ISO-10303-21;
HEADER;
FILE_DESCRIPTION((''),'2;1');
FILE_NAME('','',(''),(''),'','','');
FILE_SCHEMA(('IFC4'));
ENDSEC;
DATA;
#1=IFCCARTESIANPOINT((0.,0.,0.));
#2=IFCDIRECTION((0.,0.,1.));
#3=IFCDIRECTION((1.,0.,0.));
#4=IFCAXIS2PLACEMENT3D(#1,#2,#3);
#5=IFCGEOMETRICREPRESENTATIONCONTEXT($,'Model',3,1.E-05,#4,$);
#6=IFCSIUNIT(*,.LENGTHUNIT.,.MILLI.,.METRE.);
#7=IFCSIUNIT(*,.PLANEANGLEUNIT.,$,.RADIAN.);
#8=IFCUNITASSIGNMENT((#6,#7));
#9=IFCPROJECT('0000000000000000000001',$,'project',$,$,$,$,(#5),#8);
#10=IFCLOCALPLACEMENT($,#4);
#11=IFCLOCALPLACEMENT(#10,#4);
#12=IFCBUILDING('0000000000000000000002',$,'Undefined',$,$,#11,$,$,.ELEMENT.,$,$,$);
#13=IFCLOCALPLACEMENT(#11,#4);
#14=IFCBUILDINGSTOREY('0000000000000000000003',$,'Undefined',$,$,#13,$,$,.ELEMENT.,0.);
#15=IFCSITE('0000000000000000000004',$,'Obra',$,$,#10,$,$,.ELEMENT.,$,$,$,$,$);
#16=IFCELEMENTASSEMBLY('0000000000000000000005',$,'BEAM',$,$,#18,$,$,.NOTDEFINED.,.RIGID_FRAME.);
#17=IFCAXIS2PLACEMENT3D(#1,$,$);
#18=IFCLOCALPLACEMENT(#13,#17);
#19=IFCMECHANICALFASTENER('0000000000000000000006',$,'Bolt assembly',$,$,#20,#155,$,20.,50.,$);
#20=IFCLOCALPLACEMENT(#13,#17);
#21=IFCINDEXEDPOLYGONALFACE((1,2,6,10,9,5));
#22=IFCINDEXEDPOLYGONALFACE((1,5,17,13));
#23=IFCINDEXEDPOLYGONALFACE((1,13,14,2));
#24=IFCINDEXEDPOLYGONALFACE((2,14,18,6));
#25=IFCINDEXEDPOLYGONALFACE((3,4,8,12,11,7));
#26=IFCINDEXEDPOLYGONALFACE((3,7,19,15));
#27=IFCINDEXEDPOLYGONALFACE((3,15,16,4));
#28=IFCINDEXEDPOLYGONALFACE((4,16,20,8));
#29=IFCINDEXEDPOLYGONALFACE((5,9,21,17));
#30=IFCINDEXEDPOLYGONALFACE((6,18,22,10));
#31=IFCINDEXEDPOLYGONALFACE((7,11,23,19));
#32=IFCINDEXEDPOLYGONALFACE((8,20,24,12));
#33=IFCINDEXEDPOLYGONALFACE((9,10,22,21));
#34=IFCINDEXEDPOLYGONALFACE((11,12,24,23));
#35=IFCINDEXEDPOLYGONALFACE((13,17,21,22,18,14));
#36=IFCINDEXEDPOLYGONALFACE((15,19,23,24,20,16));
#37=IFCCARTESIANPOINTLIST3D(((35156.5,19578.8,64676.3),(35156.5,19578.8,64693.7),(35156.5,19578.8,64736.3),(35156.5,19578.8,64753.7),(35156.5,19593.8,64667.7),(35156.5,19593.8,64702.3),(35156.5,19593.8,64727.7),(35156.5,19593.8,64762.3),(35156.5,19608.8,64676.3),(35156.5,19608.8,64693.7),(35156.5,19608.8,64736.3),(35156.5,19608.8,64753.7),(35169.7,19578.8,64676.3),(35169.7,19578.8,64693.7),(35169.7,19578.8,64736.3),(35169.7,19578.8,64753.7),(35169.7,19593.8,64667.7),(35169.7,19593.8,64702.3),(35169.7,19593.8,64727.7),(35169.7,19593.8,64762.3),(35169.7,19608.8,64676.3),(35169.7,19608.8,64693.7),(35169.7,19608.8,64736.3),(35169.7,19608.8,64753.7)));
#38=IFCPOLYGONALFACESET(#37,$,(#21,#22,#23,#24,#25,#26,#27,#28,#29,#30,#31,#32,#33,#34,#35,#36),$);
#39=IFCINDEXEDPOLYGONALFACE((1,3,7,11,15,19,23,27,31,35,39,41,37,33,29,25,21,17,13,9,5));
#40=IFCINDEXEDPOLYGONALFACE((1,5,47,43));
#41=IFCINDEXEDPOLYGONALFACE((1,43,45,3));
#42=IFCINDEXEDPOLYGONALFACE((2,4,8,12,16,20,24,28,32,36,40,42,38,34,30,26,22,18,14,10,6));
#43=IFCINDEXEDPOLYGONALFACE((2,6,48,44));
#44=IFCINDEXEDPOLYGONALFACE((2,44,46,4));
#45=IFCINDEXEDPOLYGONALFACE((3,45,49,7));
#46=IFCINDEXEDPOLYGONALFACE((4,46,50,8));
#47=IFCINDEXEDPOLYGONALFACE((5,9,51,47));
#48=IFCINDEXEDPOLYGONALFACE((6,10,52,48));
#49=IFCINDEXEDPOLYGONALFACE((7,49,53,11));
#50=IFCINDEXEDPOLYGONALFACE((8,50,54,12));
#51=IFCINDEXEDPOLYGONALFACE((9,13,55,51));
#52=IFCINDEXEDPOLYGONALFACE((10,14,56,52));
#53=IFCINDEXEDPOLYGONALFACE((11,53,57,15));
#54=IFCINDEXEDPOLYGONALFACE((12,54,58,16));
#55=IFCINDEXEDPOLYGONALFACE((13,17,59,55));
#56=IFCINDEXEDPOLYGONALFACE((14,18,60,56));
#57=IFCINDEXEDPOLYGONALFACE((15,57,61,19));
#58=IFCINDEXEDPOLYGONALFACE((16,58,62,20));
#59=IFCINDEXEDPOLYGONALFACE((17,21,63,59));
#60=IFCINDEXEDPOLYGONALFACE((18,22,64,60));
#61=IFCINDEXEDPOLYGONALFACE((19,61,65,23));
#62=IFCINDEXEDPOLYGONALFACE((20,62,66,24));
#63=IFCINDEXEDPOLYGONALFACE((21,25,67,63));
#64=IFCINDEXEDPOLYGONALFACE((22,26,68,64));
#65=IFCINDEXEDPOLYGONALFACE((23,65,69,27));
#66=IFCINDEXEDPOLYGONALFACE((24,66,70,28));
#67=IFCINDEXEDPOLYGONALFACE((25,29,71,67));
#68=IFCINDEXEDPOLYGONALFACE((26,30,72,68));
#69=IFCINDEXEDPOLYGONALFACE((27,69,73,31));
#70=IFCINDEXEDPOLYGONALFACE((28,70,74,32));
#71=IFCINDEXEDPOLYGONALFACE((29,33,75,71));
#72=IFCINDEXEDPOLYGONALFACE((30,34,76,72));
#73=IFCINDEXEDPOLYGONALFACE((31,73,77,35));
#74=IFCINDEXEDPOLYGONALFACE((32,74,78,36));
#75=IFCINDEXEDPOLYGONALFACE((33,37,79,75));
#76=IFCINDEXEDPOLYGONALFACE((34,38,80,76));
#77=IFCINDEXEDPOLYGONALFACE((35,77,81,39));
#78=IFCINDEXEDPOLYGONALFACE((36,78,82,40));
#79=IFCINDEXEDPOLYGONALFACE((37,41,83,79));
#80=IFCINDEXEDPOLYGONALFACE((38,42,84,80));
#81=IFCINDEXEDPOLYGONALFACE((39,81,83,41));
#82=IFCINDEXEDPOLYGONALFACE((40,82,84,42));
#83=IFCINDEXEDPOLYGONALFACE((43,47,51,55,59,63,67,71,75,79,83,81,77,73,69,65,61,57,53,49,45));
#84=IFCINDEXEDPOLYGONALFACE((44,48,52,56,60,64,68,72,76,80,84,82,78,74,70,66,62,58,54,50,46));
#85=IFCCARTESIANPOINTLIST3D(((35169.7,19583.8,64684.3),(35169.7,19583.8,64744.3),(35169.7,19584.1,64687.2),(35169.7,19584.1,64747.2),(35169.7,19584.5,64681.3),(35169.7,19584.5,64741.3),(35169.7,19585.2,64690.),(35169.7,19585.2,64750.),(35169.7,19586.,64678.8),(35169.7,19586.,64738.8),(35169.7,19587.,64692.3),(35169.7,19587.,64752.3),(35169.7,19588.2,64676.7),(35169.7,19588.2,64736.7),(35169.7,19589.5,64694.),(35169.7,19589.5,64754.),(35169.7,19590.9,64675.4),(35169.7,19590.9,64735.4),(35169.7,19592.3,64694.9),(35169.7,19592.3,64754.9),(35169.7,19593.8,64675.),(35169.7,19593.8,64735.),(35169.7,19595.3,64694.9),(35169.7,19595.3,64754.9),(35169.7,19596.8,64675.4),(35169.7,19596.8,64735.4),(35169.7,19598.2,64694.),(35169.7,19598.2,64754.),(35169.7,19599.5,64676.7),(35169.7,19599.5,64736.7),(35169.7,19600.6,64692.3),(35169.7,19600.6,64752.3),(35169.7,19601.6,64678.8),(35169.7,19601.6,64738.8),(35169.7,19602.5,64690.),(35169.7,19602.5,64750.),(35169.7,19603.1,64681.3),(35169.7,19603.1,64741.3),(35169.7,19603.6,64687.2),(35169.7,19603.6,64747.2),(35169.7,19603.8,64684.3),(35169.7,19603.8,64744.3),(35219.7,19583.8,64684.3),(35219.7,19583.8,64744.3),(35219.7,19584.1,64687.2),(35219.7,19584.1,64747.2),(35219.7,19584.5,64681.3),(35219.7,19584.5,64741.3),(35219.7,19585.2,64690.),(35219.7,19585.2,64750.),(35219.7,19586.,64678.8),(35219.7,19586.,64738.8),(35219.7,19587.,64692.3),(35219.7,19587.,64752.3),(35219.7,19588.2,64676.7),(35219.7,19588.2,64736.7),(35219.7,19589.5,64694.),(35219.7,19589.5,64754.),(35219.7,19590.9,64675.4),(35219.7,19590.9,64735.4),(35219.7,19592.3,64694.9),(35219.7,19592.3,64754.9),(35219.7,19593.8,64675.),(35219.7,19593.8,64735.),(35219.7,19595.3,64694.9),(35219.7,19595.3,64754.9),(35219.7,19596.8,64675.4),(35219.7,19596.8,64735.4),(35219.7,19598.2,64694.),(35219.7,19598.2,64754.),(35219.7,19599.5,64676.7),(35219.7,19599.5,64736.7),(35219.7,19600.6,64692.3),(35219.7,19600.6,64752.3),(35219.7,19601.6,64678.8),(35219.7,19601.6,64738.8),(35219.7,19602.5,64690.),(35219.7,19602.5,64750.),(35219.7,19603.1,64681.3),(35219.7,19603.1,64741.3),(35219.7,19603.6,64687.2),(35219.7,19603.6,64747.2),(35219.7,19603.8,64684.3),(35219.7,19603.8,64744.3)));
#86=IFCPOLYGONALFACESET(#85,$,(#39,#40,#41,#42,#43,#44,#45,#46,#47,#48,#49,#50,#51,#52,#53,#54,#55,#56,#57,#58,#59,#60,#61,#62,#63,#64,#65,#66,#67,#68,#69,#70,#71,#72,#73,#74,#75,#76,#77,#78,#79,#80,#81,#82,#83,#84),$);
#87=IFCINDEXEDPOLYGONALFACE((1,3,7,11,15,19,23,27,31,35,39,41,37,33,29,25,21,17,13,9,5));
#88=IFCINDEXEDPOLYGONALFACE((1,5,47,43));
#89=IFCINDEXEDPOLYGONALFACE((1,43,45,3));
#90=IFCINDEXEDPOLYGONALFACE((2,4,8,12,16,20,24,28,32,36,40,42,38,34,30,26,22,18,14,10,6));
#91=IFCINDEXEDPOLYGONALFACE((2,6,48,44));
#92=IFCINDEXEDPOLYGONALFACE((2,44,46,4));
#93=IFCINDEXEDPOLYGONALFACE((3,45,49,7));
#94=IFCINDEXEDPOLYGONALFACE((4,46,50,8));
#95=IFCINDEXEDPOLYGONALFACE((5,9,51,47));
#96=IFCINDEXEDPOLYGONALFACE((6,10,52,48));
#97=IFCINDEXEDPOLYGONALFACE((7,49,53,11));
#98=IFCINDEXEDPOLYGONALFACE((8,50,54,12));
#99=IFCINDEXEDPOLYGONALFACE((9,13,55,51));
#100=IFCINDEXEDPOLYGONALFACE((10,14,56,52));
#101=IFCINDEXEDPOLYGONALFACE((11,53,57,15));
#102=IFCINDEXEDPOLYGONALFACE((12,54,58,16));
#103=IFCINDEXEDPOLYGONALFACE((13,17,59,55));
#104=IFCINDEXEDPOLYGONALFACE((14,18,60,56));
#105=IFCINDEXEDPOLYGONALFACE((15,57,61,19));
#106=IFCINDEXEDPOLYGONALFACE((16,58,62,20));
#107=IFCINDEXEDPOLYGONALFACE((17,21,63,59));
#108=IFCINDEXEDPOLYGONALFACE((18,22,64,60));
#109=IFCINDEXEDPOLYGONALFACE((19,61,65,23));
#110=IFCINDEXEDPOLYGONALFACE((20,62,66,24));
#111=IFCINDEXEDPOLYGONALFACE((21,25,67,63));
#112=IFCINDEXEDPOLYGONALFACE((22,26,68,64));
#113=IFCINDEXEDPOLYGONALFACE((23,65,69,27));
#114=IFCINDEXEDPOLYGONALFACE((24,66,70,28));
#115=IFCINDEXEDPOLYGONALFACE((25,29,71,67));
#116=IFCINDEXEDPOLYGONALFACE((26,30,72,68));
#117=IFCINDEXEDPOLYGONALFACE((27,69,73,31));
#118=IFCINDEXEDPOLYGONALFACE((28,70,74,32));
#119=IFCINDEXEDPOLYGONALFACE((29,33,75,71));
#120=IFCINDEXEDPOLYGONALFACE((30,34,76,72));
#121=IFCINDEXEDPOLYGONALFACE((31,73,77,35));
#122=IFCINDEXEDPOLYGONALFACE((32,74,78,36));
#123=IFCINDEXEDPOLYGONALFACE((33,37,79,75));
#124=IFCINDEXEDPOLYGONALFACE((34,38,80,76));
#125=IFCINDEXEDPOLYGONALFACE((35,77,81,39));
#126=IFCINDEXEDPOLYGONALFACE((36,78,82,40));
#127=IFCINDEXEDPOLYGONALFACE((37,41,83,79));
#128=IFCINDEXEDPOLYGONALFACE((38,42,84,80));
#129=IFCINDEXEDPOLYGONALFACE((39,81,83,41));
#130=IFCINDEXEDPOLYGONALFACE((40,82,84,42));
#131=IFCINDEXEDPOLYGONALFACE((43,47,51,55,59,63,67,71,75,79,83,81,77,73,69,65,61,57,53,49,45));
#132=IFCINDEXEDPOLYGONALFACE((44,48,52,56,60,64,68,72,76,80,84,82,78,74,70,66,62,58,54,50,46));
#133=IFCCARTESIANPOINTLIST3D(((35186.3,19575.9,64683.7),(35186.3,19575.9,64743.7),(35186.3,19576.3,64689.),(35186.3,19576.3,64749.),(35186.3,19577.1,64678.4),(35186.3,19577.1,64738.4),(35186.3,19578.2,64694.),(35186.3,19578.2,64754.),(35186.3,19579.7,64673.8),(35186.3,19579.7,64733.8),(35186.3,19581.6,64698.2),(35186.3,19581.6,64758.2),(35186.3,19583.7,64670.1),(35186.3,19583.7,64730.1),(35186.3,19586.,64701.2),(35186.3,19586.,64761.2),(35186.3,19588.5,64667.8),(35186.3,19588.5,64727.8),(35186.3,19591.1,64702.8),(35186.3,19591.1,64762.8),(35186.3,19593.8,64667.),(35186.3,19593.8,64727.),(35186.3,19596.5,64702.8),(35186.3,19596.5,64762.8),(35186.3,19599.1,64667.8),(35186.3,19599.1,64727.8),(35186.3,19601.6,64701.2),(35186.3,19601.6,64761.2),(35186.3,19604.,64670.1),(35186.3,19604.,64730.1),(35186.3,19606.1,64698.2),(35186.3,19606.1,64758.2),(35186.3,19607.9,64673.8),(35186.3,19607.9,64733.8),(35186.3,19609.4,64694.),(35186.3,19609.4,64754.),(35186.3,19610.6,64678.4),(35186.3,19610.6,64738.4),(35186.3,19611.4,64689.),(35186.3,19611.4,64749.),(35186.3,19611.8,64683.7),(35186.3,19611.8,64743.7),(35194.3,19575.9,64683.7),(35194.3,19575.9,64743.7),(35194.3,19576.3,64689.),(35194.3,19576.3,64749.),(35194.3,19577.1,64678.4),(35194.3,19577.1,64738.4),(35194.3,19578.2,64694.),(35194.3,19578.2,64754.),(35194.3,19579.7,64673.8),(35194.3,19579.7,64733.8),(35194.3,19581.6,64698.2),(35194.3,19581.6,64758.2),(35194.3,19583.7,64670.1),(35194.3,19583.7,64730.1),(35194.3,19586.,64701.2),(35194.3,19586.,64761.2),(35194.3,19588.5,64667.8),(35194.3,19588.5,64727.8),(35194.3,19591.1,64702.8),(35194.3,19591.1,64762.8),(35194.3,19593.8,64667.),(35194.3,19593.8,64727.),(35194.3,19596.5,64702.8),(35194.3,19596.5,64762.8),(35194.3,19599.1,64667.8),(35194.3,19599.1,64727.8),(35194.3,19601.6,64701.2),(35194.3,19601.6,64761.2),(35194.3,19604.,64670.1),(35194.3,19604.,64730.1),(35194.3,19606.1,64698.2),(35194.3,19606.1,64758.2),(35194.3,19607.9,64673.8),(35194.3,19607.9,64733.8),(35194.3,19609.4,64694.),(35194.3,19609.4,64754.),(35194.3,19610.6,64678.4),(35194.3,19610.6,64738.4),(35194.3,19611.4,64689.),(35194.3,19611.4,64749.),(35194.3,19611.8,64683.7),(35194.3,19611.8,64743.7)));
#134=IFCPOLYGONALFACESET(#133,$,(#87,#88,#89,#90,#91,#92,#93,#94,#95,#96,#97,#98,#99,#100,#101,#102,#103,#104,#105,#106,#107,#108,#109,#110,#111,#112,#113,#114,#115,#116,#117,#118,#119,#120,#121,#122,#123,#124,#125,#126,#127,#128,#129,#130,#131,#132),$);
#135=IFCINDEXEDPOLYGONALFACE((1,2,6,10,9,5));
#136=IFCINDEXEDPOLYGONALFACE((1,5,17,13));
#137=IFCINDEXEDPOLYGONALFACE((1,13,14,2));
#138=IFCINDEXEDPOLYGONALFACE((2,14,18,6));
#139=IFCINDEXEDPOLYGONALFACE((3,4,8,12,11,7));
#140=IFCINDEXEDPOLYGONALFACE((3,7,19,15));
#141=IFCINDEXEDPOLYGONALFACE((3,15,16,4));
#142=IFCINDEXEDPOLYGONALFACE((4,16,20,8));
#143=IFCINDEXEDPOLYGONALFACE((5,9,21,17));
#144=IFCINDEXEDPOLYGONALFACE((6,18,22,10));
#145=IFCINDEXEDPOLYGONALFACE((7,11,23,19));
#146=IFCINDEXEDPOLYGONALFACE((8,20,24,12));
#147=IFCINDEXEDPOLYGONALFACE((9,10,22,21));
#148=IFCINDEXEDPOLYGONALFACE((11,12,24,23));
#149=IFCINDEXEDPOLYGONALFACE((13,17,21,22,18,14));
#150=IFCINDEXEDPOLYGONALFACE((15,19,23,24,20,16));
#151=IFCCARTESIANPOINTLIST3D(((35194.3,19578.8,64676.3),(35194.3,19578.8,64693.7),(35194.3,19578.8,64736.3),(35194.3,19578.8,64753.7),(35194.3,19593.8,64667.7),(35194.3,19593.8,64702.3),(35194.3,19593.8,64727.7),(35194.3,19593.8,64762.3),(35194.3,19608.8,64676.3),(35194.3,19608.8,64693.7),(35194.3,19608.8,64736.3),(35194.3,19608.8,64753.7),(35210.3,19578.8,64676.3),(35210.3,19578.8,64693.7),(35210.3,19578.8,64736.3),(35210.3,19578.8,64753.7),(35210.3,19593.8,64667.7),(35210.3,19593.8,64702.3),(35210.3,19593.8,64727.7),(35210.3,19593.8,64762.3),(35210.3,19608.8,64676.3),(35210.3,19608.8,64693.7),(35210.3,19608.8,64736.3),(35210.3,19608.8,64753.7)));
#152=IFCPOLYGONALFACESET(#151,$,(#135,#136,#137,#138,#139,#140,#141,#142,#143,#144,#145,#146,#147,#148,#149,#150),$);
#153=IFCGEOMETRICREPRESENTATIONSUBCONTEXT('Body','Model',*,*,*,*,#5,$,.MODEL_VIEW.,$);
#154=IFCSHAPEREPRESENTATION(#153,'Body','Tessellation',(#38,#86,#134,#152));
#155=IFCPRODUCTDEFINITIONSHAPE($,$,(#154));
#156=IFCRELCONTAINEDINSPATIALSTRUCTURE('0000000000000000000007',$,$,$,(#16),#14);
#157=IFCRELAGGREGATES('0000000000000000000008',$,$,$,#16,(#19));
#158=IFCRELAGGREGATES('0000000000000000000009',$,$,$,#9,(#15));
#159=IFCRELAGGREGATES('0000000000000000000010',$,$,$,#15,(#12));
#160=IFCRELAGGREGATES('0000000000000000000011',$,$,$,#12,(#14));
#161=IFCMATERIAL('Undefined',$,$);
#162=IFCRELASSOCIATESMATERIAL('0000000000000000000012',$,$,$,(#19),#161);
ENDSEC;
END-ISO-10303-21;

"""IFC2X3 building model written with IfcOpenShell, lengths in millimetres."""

from ifc_helpers import new_model, si_unit, frame, origin_with_axes, origin_2d_with_axis, place, context, subcontext, project, spatial, polyline, circle, outline, extrude, source, transform, mapped, material, element, aggregate, save


model = new_model("IFC2X3")

# Units and contexts
model_context = context("Model", 3, precision=1e-05, world=origin_with_axes())
body_context = subcontext(model_context, "Body", "Model", "MODEL_VIEW")
ifc_project = project(units=[si_unit("LENGTHUNIT", "METRE", prefix="MILLI"), si_unit("PLANEANGLEUNIT", "RADIAN")], contexts=[model_context])

# Site, building, storey
site_placement = place(None, origin_with_axes())
site = spatial("IfcSite", under=ifc_project, at=site_placement, Name="Obra", CompositionType="ELEMENT")
building_placement = place(site_placement, origin_with_axes())
building = spatial("IfcBuilding", under=site, at=building_placement, Name="Undefined", CompositionType="ELEMENT")
storey_placement = place(building_placement, origin_with_axes())
storey = spatial("IfcBuildingStorey", under=building, at=storey_placement, Name="Undefined", CompositionType="ELEMENT", Elevation=0.0)

# Element assembly, mechanical fastener
ifc_material = material(Name="Undefined")
shared_shape_1 = source(origin_with_axes(), body_context, "Body", "SweptSolid", [
    extrude(outline(polyline([(17.3, 0.0), (8.7, 15.0), (-8.7, 15.0), (-17.3, 0.0), (-8.7, -15.0), (8.7, -15.0), (17.3, 0.0)])), frame((0.0, -26.5, 0.0), z_axis=(0.0, 1.0, 0.0), x_axis=(1.0, 0.0, 0.0)), (0.0, 0.0, 1.0), 13.2),
    extrude(circle(Radius=10.0, at=origin_2d_with_axis()), frame((0.0, -13.3, 0.0), z_axis=(0.0, 1.0, 0.0), x_axis=(1.0, 0.0, 0.0)), (0.0, 0.0, 1.0), 50.0),
    extrude(circle(Radius=18.0, at=origin_2d_with_axis()), frame((0.0, 3.3, 0.0), z_axis=(0.0, 1.0, 0.0), x_axis=(1.0, 0.0, 0.0)), (0.0, 0.0, 1.0), 8.0),
    extrude(outline(polyline([(17.3, 0.0), (8.7, 15.0), (-8.7, 15.0), (-17.3, 0.0), (-8.7, -15.0), (8.7, -15.0), (17.3, 0.0)])), frame((0.0, 11.3, 0.0), z_axis=(0.0, 1.0, 0.0), x_axis=(1.0, 0.0, 0.0)), (0.0, 0.0, 1.0), 16.0),
])
assembly_1_placement = place(storey_placement, origin_with_axes())
assembly_1 = element("IfcElementAssembly", 1, at=assembly_1_placement, inside=storey, Name="BEAM", AssemblyPlace="NOTDEFINED", PredefinedType="RIGID_FRAME")
mechanical_fastener_1_placement = place(assembly_1_placement, frame((35183.0, 19633.8, 64850.0), z_axis=(0.0, -1.0, 0.0), x_axis=(0.0, 0.0, -1.0)))
mechanical_fastener_1 = element("IfcMechanicalFastener", 2, at=mechanical_fastener_1_placement, material=ifc_material, Name="Bolt assembly", NominalDiameter=20.0, NominalLength=50.0, context=body_context, shape_type="MappedRepresentation", body=[
    mapped(shared_shape_1, transform((105.0, 0.0, 40.0))),
    mapped(shared_shape_1, transform((165.0, 0.0, 40.0))),
])

aggregate(assembly_1, [mechanical_fastener_1])

save(model, "model.ifc")
